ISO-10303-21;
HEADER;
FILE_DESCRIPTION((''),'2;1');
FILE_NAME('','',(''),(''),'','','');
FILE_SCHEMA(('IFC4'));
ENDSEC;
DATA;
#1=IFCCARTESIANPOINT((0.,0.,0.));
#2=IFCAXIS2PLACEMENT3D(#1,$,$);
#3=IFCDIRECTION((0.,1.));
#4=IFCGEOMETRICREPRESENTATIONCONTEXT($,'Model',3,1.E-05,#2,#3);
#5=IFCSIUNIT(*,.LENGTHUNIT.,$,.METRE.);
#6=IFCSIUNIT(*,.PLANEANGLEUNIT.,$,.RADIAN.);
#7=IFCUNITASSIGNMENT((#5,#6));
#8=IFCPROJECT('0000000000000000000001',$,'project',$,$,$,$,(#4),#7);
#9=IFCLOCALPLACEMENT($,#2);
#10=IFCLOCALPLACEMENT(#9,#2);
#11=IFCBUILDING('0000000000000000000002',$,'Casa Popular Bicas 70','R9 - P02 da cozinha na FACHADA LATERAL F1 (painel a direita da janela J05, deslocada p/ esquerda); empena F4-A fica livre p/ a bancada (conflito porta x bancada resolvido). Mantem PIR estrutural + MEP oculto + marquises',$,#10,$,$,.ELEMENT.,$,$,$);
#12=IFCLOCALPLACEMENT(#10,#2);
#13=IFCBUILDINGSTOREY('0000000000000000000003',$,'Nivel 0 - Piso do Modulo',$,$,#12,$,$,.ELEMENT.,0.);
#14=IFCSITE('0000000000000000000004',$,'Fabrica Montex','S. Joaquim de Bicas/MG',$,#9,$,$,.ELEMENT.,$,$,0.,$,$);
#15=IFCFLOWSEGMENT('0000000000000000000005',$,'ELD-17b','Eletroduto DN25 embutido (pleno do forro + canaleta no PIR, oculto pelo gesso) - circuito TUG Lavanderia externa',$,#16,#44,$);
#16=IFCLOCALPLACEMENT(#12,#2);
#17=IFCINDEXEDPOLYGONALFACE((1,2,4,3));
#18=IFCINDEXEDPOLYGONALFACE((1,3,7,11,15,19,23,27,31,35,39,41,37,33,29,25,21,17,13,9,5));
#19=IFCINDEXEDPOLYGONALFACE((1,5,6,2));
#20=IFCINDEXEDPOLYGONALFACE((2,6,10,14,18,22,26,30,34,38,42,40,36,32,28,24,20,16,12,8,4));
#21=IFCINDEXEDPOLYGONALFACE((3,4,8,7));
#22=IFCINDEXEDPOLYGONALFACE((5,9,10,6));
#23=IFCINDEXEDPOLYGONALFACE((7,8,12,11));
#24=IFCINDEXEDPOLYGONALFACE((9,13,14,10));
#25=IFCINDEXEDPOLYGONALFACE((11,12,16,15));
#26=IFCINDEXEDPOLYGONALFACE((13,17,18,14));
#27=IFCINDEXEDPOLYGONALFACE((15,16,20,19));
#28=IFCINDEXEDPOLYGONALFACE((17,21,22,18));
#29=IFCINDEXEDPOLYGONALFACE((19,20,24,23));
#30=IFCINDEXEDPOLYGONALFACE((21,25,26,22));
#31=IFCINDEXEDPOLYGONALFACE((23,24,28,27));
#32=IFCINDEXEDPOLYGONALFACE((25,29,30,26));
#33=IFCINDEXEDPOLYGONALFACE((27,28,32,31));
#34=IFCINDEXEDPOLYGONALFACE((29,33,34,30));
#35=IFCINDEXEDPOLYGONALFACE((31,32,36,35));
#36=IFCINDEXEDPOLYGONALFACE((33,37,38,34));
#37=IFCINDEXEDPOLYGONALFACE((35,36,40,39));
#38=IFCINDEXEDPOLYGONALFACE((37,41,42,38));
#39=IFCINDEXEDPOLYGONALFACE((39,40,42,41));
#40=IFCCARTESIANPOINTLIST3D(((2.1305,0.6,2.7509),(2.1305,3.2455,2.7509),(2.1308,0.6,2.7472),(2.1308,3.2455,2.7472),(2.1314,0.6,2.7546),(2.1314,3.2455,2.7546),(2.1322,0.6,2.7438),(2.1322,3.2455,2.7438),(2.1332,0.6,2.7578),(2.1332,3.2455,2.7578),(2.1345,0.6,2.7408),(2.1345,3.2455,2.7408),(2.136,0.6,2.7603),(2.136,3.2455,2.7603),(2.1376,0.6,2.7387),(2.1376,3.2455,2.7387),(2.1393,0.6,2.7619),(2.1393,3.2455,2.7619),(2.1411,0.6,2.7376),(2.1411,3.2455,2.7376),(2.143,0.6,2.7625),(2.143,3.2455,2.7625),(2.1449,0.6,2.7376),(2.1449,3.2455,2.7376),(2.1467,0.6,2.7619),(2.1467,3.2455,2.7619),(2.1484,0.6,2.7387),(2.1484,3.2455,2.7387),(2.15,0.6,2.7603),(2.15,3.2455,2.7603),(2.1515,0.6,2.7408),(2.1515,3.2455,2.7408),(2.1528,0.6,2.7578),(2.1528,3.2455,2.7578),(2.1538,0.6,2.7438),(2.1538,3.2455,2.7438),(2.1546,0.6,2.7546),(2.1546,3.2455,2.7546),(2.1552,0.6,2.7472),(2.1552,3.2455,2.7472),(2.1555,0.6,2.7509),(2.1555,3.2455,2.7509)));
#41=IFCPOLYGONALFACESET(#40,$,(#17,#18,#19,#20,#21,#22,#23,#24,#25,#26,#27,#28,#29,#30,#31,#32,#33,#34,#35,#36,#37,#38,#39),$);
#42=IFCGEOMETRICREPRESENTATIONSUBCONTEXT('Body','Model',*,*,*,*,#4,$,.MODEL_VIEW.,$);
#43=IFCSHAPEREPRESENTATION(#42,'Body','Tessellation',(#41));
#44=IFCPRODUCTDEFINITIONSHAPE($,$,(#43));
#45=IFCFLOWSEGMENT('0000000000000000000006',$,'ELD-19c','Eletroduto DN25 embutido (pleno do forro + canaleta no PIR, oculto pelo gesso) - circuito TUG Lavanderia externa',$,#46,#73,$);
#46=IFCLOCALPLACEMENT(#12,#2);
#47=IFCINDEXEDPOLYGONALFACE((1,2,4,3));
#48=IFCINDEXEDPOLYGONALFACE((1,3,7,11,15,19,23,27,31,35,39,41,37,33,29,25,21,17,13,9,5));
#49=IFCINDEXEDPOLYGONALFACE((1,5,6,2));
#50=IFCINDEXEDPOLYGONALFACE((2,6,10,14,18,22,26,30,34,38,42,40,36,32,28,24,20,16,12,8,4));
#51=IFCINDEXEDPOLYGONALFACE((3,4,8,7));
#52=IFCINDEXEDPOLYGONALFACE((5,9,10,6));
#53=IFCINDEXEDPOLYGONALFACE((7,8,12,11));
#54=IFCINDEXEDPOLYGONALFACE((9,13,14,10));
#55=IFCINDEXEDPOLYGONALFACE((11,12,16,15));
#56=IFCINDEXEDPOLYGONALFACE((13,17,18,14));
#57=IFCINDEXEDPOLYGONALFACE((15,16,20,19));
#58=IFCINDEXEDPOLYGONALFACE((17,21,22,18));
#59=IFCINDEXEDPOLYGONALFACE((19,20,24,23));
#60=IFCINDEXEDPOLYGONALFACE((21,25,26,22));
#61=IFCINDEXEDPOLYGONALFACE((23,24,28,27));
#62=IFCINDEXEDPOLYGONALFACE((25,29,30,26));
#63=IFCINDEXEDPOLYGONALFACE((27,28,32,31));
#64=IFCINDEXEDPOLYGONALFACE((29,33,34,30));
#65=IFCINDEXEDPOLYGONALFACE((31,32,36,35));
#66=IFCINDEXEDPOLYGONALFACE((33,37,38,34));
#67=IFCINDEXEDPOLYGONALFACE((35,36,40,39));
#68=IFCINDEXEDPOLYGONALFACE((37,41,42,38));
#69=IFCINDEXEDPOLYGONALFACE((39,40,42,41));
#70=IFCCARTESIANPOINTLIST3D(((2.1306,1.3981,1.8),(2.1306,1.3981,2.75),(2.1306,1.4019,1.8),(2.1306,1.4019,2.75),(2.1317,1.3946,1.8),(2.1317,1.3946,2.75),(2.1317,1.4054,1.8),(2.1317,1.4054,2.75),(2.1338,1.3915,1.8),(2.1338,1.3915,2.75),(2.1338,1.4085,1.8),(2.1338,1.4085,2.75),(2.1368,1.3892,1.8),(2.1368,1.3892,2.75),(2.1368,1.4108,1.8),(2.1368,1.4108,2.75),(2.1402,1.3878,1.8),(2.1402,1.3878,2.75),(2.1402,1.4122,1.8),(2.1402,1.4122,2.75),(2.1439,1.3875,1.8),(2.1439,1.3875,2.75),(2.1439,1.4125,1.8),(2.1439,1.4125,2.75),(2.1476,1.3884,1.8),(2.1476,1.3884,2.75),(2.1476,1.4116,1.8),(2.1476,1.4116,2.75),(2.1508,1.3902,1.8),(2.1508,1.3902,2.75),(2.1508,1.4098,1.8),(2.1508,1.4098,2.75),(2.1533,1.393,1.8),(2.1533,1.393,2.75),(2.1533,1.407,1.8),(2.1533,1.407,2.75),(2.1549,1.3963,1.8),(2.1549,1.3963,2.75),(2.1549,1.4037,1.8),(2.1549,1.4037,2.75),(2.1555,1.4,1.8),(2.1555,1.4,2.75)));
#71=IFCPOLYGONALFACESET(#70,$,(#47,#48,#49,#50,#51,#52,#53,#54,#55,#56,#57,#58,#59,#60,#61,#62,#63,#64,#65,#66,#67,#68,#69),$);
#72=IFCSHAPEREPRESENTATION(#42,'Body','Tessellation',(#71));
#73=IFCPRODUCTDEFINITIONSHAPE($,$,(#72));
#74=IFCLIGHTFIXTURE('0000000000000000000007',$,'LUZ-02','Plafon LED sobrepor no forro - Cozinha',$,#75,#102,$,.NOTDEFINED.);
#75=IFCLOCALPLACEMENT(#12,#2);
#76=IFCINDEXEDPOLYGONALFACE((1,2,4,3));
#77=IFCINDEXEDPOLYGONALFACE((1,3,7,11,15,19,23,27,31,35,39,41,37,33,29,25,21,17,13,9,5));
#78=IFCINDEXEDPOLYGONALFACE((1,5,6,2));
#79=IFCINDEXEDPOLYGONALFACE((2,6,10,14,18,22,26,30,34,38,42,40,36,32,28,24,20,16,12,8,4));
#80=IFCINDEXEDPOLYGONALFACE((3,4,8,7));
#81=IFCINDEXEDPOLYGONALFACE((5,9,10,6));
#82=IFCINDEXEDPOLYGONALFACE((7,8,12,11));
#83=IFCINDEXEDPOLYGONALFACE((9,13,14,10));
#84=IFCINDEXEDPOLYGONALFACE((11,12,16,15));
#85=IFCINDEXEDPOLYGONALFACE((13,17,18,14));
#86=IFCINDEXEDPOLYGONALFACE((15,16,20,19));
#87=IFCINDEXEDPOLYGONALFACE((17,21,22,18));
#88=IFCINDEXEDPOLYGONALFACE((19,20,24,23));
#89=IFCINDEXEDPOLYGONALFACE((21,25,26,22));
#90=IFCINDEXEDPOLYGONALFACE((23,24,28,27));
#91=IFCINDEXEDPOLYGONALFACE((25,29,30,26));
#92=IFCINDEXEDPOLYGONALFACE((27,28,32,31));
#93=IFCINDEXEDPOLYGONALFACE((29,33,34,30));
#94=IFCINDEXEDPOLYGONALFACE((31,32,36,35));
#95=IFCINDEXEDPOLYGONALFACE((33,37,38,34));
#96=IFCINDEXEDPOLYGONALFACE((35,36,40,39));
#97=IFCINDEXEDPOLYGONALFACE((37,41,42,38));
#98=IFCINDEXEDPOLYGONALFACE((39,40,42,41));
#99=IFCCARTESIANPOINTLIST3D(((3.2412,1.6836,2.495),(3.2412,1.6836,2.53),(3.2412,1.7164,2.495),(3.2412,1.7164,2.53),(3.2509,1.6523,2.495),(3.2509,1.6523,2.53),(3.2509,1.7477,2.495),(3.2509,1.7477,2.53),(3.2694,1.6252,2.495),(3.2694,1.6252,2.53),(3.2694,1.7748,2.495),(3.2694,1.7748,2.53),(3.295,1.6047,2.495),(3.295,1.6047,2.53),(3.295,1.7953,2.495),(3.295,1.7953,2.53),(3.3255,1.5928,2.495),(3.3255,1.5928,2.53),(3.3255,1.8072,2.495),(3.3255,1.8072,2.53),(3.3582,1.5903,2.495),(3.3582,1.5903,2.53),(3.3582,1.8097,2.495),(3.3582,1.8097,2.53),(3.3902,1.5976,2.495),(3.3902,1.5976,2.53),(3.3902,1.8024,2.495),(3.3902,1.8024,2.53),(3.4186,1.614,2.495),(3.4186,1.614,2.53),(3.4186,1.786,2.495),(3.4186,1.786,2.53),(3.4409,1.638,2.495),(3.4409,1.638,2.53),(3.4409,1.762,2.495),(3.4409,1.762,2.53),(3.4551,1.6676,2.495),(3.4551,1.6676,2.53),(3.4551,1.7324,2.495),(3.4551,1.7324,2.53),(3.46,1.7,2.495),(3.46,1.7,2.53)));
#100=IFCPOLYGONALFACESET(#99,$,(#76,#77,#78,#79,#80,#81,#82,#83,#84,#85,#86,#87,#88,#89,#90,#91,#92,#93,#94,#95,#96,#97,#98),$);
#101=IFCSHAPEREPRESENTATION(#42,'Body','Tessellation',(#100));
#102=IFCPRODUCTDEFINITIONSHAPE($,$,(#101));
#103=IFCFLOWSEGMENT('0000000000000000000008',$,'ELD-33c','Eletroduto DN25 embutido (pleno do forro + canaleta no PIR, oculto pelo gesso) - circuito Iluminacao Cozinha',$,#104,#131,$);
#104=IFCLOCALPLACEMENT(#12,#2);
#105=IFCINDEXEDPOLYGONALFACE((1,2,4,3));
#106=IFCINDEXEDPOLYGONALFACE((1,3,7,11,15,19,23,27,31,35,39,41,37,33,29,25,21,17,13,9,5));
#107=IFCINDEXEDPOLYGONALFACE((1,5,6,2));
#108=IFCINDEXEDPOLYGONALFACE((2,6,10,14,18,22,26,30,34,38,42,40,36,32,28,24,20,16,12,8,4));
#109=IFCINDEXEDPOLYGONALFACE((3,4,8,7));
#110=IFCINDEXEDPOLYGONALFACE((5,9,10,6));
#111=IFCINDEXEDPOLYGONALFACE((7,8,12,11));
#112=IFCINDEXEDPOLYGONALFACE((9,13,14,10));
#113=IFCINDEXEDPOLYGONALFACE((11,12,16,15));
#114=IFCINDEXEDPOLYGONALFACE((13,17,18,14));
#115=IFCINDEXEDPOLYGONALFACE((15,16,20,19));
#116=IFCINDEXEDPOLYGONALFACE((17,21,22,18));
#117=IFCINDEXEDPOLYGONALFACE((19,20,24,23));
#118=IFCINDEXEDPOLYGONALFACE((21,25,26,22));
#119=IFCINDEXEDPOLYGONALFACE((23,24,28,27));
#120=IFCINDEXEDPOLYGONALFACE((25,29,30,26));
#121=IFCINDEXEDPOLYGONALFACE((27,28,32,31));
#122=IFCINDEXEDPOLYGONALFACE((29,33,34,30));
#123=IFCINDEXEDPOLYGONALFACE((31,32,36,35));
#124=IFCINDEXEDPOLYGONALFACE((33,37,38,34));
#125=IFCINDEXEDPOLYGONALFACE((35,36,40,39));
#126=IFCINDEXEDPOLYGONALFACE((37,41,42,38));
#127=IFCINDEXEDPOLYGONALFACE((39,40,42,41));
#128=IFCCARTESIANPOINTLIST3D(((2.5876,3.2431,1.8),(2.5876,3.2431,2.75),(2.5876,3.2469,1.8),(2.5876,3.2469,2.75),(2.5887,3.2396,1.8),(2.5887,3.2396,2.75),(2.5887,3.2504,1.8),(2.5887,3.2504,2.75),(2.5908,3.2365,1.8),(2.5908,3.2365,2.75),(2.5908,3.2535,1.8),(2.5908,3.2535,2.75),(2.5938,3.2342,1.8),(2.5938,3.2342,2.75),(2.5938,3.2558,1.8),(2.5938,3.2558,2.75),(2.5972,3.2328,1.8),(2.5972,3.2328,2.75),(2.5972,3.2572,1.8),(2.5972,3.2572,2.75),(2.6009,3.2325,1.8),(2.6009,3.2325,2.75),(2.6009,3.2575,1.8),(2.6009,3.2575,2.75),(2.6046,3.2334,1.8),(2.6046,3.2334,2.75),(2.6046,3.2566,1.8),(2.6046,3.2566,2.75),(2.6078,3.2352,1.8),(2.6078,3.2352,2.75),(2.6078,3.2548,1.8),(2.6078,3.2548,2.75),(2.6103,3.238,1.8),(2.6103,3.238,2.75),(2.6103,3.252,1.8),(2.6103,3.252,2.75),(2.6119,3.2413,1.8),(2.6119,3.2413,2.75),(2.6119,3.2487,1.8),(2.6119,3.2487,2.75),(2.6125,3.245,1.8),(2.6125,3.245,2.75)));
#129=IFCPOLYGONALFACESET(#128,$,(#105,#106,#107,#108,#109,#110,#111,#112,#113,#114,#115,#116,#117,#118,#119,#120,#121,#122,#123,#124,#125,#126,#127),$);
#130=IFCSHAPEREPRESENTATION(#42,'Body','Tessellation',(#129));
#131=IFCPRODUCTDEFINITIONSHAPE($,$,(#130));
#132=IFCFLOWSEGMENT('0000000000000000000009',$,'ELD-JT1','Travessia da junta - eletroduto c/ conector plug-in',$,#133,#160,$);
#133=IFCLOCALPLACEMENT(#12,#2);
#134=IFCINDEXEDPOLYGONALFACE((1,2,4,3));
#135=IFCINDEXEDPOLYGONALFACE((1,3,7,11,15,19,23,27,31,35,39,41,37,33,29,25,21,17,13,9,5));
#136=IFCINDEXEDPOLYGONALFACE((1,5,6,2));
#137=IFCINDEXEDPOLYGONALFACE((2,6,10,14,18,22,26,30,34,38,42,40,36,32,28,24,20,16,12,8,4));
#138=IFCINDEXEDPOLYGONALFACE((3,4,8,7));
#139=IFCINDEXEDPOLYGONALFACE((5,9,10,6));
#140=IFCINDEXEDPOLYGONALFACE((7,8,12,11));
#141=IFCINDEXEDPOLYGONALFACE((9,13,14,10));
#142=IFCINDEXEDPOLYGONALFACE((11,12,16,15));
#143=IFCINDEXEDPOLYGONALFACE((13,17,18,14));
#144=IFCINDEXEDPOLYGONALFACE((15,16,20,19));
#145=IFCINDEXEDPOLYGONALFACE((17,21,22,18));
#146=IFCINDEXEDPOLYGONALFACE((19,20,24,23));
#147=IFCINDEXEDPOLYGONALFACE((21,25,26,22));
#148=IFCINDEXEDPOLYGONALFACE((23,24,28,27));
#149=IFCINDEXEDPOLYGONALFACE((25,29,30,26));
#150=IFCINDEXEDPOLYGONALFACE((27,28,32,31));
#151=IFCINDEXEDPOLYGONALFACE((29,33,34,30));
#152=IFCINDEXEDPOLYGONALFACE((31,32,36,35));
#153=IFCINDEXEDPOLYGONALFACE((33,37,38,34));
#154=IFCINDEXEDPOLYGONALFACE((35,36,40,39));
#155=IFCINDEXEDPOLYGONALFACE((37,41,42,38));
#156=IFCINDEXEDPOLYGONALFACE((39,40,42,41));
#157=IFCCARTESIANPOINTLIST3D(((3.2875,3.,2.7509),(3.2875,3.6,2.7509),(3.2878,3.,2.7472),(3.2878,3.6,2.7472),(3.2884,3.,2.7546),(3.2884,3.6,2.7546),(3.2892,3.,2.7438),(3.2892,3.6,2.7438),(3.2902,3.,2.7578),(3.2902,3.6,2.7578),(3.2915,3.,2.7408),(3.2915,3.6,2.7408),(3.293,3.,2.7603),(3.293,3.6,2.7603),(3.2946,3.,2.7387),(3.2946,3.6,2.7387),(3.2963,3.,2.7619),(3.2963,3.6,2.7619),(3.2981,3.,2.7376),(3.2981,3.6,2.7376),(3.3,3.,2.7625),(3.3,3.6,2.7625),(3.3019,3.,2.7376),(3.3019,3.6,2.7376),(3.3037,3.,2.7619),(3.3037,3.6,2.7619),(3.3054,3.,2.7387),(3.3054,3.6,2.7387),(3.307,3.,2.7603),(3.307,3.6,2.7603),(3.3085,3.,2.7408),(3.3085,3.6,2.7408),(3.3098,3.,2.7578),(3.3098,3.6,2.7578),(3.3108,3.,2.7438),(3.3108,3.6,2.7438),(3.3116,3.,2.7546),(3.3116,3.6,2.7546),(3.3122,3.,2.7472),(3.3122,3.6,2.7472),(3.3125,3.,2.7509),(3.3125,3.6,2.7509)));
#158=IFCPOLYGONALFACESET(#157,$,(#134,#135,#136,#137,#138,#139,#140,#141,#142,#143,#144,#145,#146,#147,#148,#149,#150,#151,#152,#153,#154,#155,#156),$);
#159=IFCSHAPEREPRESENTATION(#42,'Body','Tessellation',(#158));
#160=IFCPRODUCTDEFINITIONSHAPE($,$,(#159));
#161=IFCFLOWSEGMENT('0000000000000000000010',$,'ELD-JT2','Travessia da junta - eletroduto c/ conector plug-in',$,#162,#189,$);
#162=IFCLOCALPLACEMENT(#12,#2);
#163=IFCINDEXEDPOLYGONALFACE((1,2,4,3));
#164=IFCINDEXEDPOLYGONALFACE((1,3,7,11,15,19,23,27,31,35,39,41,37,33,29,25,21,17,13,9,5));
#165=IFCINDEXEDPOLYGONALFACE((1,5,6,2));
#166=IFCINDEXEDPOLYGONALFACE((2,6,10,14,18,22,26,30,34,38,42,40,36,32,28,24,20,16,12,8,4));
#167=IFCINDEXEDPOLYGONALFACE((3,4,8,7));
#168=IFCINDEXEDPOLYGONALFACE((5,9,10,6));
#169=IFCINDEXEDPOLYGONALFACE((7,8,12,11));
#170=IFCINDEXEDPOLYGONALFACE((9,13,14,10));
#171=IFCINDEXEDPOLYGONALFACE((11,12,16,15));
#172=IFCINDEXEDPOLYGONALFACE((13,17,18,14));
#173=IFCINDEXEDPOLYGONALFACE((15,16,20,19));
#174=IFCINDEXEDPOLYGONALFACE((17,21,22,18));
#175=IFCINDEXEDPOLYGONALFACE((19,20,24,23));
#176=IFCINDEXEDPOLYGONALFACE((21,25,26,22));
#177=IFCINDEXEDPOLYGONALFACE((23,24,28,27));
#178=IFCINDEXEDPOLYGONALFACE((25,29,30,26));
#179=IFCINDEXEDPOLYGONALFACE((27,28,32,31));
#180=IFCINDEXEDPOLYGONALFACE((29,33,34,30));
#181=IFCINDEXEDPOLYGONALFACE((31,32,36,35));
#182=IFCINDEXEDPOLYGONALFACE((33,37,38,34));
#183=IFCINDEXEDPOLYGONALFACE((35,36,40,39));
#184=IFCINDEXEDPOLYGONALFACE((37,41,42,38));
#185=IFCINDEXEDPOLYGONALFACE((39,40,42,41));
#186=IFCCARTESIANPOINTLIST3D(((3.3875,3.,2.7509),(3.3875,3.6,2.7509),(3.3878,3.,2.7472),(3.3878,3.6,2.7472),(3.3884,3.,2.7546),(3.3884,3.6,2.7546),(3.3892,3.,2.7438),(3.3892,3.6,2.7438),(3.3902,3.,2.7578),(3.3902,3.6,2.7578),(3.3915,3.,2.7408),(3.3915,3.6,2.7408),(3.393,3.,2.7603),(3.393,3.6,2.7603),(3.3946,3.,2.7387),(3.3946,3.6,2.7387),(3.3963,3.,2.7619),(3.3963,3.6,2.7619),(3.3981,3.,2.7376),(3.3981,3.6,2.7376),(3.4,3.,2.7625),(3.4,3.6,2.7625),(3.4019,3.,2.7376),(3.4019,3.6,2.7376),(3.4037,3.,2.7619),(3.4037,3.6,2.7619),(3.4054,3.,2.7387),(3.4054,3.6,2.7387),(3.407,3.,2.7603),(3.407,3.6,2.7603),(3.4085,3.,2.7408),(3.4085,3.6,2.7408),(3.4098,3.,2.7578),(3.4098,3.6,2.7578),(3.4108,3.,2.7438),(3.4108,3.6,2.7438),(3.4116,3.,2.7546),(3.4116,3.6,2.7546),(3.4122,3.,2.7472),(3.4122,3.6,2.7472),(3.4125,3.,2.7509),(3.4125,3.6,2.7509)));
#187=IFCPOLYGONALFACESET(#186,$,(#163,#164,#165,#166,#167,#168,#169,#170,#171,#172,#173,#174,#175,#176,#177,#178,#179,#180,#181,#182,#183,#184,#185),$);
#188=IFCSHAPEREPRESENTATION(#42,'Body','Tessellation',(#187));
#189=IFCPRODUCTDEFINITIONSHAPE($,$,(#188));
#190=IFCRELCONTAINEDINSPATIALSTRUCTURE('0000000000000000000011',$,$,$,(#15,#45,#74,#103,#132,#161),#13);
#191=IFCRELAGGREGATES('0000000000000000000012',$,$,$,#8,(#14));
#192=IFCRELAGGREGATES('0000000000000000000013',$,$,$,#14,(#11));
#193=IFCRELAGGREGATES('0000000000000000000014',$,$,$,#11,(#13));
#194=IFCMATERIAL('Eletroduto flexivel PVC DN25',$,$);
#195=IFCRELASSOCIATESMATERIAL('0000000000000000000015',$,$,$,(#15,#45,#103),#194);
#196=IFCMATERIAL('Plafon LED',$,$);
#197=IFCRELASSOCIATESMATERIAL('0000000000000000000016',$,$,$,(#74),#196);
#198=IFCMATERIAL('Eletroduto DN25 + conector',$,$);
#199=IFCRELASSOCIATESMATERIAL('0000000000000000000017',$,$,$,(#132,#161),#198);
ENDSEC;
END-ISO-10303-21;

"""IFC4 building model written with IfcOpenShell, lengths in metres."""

from ifc_helpers import new_model, si_unit, direction, frame, origin, origin_2d, place, context, subcontext, project, spatial, circle, extrude, material, element, save


model = new_model("IFC4")

# Units and contexts
model_context = context("Model", 3, precision=1e-05, world=origin(), true_north=direction((0.0, 1.0)))
body_context = subcontext(model_context, "Body", "Model", "MODEL_VIEW")
ifc_project = project(units=[si_unit("LENGTHUNIT", "METRE"), si_unit("PLANEANGLEUNIT", "RADIAN")], contexts=[model_context])

# Site, building, storey
site_placement = place(None, origin())
site = spatial("IfcSite", under=ifc_project, at=site_placement, Name="Fabrica Montex", Description="S. Joaquim de Bicas/MG", CompositionType="ELEMENT", RefElevation=0.0)
building_placement = place(site_placement, origin())
building = spatial("IfcBuilding", under=site, at=building_placement, Name="Casa Popular Bicas 70", Description="R9 - P02 da cozinha na FACHADA LATERAL F1 (painel a direita da janela J05, deslocada p/ esquerda); empena F4-A fica livre p/ a bancada (conflito porta x bancada resolvido). Mantem PIR estrutural + MEP oculto + marquises", CompositionType="ELEMENT")
storey_placement = place(building_placement, origin())
storey = spatial("IfcBuildingStorey", under=building, at=storey_placement, Name="Nivel 0 - Piso do Modulo", CompositionType="ELEMENT", Elevation=0.0)

# Flow segments
ifc_material_1 = material(Name="Eletroduto flexivel PVC DN25")
flow_segment_1_placement = place(storey_placement, frame((2.143, 3.2455, 2.75), z_axis=(0.0, -1.0, 0.0), x_axis=(0.0, 0.0, 1.0)))
element("IfcFlowSegment", 1, at=flow_segment_1_placement, inside=storey, material=ifc_material_1, Name="ELD-17b", Description="Eletroduto DN25 embutido (pleno do forro + canaleta no PIR, oculto pelo gesso) - circuito TUG Lavanderia externa", context=body_context, shape_type="SweptSolid", body=[
    extrude(circle(Radius=0.0125, at=origin_2d()), origin(), (0.0, 0.0, 1.0), 2.6455),
])
for number, where, z_axis, x_axis, name in (
    (2, (2.143, 1.4, 2.75), (0.0, 0.0, -1.0), (1.0, 0.0, 0.0), "ELD-19c"),
):
    element("IfcFlowSegment", number, at=place(storey_placement, frame(where, z_axis=z_axis, x_axis=x_axis)), inside=storey, material=ifc_material_1, Name=name, Description="Eletroduto DN25 embutido (pleno do forro + canaleta no PIR, oculto pelo gesso) - circuito TUG Lavanderia externa", context=body_context, shape_type="SweptSolid", body=[
        extrude(circle(Radius=0.0125, at=origin_2d()), origin(), (0.0, 0.0, 1.0), 0.95),
    ])

# Light fixture
ifc_material_2 = material(Name="Plafon LED")
light_fixture_placement = place(storey_placement, frame((3.35, 1.7, 2.495)))
element("IfcLightFixture", 3, at=light_fixture_placement, inside=storey, material=ifc_material_2, Name="LUZ-02", Description="Plafon LED sobrepor no forro - Cozinha", PredefinedType="NOTDEFINED", context=body_context, shape_type="SweptSolid", body=[
    extrude(circle(Radius=0.11, at=origin_2d()), origin(), (0.0, 0.0, 1.0), 0.035),
])

# Flow segments
flow_segment_2_placement = place(storey_placement, frame((2.6, 3.245, 2.75), z_axis=(0.0, 0.0, -1.0), x_axis=(1.0, 0.0, 0.0)))
element("IfcFlowSegment", 4, at=flow_segment_2_placement, inside=storey, material=ifc_material_1, Name="ELD-33c", Description="Eletroduto DN25 embutido (pleno do forro + canaleta no PIR, oculto pelo gesso) - circuito Iluminacao Cozinha", context=body_context, shape_type="SweptSolid", body=[
    extrude(circle(Radius=0.0125, at=origin_2d()), origin(), (0.0, 0.0, 1.0), 0.95),
])
ifc_material_3 = material(Name="Eletroduto DN25 + conector")
for number, where, z_axis, x_axis, name in (
    (5, (3.3, 3.0, 2.75), (0.0, 1.0, 0.0), (0.0, 0.0, 1.0), "ELD-JT1"),
    (6, (3.4, 3.0, 2.75), (0.0, 1.0, 0.0), (0.0, 0.0, 1.0), "ELD-JT2"),
):
    element("IfcFlowSegment", number, at=place(storey_placement, frame(where, z_axis=z_axis, x_axis=x_axis)), inside=storey, material=ifc_material_3, Name=name, Description="Travessia da junta - eletroduto c/ conector plug-in", context=body_context, shape_type="SweptSolid", body=[
        extrude(circle(Radius=0.0125, at=origin_2d()), origin(), (0.0, 0.0, 1.0), 0.6),
    ])

save(model, "model.ifc")
